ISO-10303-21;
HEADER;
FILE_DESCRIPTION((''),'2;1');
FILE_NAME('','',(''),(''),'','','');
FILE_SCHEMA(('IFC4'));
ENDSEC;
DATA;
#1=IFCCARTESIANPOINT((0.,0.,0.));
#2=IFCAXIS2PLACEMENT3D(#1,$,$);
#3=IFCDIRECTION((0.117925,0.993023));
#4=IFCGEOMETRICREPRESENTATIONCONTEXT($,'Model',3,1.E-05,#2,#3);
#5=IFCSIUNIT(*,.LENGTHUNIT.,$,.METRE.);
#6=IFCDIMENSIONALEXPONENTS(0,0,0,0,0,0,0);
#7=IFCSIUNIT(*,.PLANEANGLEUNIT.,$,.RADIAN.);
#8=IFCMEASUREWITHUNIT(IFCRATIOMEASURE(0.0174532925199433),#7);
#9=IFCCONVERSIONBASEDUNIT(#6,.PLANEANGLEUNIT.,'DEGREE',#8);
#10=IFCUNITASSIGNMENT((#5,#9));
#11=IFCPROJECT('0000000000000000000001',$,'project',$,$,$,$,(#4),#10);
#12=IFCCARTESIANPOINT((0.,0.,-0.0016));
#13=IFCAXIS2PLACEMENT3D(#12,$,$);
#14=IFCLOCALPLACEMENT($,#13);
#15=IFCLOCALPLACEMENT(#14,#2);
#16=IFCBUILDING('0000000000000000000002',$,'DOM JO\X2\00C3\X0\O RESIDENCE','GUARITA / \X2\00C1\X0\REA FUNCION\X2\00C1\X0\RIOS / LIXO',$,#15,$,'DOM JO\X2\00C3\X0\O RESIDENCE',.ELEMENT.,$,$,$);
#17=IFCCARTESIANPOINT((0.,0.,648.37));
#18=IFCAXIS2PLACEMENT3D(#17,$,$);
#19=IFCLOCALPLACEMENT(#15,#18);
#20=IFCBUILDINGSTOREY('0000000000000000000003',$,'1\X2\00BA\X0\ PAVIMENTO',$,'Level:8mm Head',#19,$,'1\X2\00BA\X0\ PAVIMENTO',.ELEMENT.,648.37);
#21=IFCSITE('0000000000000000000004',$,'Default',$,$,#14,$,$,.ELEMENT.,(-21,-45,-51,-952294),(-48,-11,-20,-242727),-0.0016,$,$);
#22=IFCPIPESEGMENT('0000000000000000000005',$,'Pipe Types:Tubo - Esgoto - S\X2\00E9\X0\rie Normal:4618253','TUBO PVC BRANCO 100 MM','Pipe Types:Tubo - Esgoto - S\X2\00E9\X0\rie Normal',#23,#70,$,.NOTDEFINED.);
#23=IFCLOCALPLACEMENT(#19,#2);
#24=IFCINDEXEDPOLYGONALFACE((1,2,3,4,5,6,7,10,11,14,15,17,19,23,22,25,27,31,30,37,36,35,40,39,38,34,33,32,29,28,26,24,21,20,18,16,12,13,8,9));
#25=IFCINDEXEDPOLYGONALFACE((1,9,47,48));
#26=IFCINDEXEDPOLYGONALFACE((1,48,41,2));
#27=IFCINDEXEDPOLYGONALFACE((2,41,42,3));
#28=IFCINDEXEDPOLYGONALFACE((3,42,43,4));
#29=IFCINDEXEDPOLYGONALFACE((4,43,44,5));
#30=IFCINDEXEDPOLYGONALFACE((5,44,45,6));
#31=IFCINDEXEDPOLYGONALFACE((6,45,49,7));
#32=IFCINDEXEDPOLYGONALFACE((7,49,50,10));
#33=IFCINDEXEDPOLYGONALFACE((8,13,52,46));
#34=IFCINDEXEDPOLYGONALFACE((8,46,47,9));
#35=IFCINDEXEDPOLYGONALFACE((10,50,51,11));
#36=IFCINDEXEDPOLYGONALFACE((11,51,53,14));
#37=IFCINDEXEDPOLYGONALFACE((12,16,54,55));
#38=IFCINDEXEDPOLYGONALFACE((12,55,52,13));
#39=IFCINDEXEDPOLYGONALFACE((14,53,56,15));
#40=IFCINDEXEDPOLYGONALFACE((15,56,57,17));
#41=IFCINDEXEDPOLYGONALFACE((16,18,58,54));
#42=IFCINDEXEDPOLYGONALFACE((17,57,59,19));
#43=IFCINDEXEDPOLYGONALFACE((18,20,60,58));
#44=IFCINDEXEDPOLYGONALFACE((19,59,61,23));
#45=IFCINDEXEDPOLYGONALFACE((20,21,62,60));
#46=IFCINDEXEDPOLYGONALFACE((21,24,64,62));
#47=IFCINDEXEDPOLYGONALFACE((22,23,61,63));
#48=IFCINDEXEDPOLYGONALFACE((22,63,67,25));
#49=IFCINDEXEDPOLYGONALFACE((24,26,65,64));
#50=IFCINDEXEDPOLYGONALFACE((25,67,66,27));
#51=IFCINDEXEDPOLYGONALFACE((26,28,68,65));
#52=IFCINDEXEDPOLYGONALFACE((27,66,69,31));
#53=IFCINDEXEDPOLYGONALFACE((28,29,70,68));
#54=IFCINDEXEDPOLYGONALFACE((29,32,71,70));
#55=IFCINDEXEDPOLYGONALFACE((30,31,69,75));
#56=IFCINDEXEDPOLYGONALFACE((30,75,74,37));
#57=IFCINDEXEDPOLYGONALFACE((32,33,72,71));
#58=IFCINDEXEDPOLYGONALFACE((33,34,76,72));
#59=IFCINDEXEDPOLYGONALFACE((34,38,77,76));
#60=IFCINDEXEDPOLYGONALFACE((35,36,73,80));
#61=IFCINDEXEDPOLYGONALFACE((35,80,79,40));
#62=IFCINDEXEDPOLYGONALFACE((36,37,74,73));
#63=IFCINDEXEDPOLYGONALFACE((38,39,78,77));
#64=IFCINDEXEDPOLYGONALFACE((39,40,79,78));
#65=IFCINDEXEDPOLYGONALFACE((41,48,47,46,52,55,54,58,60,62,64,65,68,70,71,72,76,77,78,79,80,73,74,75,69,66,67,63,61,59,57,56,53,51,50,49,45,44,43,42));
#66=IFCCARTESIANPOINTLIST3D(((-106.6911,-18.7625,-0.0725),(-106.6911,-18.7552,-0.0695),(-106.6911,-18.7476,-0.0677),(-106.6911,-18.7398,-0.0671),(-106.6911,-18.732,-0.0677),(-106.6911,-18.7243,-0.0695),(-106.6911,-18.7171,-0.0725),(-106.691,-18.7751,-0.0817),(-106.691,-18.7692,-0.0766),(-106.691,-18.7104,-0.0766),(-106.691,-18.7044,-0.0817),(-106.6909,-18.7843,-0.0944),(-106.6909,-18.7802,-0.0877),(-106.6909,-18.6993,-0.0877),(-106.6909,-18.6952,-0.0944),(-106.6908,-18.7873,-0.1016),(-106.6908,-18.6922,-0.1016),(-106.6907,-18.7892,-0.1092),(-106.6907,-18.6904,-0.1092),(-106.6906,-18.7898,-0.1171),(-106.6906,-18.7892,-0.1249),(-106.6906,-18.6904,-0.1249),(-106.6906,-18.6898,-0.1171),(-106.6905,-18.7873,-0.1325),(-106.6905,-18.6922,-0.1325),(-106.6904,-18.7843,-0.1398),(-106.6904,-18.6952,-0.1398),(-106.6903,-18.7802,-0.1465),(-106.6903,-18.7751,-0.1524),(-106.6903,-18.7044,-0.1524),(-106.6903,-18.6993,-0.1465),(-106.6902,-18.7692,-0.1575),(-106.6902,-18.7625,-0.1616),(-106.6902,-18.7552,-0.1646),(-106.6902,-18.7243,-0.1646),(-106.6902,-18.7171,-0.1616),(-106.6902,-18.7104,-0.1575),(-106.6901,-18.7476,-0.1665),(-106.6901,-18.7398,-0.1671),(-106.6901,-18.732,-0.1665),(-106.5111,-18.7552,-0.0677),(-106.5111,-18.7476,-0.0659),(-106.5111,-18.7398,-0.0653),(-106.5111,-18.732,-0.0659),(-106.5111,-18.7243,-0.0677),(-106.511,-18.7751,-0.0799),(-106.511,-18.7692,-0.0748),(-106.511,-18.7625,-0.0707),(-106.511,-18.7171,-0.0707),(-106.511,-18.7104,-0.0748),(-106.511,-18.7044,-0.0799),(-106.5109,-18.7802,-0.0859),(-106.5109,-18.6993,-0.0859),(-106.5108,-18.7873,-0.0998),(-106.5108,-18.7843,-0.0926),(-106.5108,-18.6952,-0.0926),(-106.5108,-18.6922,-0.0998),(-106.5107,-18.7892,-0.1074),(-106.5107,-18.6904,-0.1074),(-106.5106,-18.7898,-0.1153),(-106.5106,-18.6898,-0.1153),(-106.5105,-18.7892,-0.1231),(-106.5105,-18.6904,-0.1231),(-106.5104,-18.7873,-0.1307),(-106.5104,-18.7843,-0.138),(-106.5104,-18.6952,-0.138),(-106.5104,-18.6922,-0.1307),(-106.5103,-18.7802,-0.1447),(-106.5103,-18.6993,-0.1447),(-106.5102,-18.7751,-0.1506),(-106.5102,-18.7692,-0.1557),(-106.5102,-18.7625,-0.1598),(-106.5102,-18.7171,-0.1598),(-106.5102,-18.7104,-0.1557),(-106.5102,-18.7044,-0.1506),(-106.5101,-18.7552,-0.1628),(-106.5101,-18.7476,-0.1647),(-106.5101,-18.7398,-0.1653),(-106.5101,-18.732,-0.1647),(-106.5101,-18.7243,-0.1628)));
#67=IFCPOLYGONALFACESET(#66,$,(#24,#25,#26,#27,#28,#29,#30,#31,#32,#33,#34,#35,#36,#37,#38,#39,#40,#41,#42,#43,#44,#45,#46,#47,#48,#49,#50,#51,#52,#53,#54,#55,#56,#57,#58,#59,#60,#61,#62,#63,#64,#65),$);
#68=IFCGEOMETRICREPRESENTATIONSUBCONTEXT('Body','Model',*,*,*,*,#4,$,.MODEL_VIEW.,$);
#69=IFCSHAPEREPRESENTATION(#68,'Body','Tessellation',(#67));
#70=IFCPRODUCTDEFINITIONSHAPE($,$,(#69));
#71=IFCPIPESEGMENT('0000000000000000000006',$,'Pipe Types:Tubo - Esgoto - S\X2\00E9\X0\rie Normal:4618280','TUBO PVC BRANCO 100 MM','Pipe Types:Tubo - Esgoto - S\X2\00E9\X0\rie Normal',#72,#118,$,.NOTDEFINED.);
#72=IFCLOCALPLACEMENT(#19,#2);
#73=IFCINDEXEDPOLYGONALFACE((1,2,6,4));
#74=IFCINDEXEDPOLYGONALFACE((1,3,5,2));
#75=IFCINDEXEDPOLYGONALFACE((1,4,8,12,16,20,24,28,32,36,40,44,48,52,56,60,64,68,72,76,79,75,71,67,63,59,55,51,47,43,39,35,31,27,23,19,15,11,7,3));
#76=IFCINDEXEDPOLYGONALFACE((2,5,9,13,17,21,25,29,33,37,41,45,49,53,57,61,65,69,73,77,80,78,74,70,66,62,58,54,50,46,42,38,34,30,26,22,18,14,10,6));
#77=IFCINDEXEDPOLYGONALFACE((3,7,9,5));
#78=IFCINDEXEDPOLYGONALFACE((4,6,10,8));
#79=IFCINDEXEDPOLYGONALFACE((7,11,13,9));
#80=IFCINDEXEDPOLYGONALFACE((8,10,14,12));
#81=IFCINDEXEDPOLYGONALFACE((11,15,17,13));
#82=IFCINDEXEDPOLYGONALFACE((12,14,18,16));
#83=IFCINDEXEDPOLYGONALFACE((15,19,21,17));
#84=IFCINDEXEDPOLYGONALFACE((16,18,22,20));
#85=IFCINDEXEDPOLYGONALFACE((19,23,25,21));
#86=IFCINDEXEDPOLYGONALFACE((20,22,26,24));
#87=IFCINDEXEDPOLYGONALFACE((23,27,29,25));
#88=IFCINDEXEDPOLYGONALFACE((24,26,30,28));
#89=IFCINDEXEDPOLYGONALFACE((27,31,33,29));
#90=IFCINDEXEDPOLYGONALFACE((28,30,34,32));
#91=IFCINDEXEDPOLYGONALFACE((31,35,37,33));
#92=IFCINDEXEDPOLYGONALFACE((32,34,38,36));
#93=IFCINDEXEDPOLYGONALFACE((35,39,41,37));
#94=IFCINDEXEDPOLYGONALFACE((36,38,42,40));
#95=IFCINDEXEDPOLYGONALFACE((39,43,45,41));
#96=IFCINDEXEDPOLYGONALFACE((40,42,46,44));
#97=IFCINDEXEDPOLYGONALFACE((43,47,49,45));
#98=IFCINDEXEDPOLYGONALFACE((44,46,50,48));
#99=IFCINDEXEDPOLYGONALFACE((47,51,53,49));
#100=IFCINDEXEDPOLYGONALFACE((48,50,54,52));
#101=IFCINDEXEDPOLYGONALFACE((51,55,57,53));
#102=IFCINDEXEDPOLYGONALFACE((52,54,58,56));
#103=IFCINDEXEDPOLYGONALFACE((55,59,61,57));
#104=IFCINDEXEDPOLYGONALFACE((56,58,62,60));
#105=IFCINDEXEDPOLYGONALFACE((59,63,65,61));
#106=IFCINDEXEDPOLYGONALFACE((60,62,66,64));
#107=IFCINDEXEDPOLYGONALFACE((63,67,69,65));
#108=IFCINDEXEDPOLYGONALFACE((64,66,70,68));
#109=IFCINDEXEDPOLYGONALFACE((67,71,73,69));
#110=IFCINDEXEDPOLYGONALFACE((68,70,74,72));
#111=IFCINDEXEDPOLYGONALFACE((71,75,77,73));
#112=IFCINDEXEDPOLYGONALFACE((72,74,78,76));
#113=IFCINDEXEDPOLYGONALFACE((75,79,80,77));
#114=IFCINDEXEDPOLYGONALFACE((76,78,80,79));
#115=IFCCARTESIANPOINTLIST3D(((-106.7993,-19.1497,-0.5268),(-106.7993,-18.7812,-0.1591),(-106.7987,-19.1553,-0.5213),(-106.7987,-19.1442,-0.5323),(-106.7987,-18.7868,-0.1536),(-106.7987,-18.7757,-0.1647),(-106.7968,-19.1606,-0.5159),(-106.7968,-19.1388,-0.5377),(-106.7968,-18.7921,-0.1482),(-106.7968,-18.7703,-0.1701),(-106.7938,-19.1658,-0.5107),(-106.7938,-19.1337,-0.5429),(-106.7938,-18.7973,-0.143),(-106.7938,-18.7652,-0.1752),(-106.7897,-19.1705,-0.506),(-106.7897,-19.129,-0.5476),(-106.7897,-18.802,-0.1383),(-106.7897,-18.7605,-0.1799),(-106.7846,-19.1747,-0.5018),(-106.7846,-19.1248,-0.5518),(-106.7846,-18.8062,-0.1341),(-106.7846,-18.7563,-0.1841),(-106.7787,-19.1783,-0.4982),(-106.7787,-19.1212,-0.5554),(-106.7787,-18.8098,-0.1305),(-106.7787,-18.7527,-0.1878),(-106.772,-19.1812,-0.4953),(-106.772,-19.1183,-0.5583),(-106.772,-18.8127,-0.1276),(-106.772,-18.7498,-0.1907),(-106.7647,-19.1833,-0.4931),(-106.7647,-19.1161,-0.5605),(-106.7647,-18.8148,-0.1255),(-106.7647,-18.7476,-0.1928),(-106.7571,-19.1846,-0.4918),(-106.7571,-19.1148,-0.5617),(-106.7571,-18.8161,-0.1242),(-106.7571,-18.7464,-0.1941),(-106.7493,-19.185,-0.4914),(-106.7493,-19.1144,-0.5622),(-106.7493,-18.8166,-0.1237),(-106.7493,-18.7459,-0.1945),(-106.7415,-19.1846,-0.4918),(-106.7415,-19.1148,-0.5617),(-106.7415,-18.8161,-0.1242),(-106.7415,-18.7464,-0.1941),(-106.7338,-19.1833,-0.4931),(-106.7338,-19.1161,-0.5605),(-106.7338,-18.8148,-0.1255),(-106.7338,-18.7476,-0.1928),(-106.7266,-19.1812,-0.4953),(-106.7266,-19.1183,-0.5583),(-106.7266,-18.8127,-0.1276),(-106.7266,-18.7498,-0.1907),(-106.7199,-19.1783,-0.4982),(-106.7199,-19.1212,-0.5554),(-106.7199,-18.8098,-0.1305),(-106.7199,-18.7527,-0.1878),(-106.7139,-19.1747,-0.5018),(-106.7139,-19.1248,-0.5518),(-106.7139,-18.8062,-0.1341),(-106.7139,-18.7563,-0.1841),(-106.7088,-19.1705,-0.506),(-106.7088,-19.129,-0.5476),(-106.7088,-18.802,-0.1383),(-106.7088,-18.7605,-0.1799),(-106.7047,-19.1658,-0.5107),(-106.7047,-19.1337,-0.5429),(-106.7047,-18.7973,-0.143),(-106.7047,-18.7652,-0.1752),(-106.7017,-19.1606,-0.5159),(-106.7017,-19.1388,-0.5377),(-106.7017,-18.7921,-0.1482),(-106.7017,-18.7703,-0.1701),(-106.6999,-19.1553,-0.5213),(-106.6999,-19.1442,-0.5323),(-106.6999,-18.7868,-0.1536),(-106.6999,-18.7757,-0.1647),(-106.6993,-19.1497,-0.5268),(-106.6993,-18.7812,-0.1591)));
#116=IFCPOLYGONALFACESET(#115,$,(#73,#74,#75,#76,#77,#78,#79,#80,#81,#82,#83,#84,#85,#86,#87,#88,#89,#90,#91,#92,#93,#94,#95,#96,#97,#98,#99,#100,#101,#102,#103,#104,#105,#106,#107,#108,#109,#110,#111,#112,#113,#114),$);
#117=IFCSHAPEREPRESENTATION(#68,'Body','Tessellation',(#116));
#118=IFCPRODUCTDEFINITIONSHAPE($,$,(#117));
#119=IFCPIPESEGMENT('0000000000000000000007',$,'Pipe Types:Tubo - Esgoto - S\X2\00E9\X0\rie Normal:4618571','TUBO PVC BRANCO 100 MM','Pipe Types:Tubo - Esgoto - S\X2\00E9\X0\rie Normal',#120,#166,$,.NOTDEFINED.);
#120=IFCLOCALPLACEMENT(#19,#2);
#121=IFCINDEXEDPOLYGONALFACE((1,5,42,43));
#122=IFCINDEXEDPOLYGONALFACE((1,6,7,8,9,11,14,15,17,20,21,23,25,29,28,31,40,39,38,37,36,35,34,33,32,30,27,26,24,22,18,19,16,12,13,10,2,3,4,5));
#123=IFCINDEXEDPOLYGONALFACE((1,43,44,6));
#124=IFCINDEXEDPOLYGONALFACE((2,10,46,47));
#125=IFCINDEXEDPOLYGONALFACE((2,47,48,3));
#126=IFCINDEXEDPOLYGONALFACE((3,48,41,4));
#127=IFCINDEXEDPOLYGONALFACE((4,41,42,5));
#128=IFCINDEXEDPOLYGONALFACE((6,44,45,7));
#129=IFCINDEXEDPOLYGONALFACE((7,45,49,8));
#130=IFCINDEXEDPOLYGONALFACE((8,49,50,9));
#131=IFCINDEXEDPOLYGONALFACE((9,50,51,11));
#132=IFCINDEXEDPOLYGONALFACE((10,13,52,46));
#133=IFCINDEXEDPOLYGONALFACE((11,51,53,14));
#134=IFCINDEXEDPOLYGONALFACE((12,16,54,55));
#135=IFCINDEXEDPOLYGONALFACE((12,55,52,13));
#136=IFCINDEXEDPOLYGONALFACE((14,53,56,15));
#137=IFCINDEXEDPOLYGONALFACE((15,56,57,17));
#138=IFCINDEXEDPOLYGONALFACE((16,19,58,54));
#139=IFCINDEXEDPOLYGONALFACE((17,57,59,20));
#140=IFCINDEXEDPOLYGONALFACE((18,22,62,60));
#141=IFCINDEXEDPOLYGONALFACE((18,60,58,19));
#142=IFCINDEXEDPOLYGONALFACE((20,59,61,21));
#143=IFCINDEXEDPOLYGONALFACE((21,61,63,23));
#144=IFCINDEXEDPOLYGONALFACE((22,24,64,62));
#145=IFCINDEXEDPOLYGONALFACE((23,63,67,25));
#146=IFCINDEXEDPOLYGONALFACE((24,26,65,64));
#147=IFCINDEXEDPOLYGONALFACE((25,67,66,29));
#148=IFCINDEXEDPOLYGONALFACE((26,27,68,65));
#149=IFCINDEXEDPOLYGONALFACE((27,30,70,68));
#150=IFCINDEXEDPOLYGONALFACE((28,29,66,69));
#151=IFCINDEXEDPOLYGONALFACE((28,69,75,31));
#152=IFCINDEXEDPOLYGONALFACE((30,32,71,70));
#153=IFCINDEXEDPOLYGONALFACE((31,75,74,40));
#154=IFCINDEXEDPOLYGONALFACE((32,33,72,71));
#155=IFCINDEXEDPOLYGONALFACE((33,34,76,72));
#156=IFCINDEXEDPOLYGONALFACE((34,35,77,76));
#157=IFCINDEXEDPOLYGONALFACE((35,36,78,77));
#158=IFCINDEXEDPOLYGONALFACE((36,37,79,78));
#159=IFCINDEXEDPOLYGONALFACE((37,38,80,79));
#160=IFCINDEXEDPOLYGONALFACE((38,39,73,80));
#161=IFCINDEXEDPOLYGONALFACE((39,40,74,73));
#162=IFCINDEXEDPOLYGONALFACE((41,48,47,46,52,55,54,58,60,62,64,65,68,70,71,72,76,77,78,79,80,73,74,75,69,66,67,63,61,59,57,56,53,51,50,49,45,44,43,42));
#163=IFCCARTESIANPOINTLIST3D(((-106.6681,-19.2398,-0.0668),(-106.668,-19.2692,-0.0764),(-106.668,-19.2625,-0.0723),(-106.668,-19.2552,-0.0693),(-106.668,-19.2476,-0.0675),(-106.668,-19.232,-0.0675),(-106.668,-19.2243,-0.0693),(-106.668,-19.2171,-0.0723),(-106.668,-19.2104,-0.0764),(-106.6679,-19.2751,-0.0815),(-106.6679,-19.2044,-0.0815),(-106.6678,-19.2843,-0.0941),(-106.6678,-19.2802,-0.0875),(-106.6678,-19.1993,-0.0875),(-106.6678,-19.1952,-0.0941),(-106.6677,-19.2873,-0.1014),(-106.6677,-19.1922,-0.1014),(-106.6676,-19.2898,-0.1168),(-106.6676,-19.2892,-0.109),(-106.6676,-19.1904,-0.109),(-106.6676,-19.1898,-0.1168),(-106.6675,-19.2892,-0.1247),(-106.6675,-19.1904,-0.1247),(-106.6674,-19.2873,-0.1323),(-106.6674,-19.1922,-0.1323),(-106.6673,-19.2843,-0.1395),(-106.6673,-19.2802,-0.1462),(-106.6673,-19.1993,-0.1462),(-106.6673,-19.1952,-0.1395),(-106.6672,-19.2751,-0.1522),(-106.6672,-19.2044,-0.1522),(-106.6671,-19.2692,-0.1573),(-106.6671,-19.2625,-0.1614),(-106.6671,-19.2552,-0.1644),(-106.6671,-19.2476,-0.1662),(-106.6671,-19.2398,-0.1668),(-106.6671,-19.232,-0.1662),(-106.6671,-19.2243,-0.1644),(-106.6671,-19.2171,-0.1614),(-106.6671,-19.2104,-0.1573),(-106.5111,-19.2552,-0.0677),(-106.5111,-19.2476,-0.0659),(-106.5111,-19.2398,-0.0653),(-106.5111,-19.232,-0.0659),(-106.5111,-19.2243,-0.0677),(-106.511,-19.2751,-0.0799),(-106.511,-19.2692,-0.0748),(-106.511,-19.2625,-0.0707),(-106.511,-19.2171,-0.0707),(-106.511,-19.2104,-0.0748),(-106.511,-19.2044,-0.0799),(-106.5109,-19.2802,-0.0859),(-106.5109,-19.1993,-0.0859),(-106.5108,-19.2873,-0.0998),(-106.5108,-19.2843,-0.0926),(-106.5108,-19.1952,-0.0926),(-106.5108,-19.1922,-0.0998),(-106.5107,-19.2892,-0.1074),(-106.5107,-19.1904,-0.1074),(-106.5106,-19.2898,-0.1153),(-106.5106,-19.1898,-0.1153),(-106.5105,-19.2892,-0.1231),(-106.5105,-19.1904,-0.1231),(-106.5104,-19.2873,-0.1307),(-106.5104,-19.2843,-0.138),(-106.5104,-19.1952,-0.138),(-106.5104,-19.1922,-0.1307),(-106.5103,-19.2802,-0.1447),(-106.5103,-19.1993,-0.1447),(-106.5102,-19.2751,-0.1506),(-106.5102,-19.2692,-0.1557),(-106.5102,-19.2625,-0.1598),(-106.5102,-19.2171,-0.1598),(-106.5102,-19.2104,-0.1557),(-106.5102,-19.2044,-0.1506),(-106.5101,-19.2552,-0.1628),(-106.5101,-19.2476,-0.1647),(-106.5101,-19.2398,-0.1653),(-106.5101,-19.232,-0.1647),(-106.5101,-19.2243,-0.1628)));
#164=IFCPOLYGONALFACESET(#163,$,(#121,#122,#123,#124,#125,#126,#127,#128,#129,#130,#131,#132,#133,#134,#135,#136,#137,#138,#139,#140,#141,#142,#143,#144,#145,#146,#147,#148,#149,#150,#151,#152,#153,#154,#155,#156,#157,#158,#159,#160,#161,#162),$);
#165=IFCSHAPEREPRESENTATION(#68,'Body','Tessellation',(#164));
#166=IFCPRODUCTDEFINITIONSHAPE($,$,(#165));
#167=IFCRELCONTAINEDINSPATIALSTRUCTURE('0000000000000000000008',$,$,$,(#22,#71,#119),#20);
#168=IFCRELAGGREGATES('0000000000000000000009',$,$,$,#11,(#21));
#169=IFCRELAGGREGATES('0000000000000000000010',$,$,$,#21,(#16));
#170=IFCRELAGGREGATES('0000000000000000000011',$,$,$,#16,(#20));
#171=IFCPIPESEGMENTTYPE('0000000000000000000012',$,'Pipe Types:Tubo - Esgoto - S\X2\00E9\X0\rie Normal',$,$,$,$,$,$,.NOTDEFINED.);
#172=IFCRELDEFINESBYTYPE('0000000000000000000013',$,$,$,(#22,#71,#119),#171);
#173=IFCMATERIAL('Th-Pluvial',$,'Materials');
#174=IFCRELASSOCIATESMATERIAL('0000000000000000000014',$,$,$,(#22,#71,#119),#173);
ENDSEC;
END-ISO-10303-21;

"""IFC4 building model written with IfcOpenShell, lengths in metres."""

from ifc_helpers import new_model, entity, si_unit, converted_unit, direction, frame, origin, place, context, subcontext, project, spatial, indexed_curve, outline, extrude, material, type_object, element, save


model = new_model("IFC4")

# Units and contexts
model_context = context("Model", 3, precision=1e-05, world=origin(), true_north=direction((0.117925, 0.993023)))
body_context = subcontext(model_context, "Body", "Model", "MODEL_VIEW")
ifc_project = project(units=[si_unit("LENGTHUNIT", "METRE"), converted_unit("PLANEANGLEUNIT", "DEGREE", entity("IfcRatioMeasure", 0.0174532925199433), si_unit("PLANEANGLEUNIT", "RADIAN"), dimensions=[0, 0, 0, 0, 0, 0, 0])], contexts=[model_context])

# Site, building, storey
site_placement = place(None, frame((0.0, 0.0, -0.0016)))
site = spatial("IfcSite", under=ifc_project, at=site_placement, Name="Default", CompositionType="ELEMENT", RefLatitude=(-21, -45, -51, -952294), RefLongitude=(-48, -11, -20, -242727), RefElevation=-0.0016)
building_placement = place(site_placement, origin())
building = spatial("IfcBuilding", under=site, at=building_placement, Name="DOM JOÃO RESIDENCE", Description="GUARITA / ÁREA FUNCIONÁRIOS / LIXO", LongName="DOM JOÃO RESIDENCE", CompositionType="ELEMENT")
storey_placement = place(building_placement, frame((0.0, 0.0, 648.37)))
storey = spatial("IfcBuildingStorey", under=building, at=storey_placement, Name="1º PAVIMENTO", ObjectType="Level:8mm Head", LongName="1º PAVIMENTO", CompositionType="ELEMENT", Elevation=648.37)

# Pipe segments
ifc_material = material(Name="Th-Pluvial", Category="Materials")
pipe_segment_type = type_object("IfcPipeSegmentType", Name="Pipe Types:Tubo - Esgoto - Série Normal", PredefinedType="NOTDEFINED")
pipe_segment_1_placement = place(storey_placement, frame((-106.6927, -18.7914, -0.1687)))
element("IfcPipeSegment", 1, at=pipe_segment_1_placement, inside=storey, type_object=pipe_segment_type, material=ifc_material, Name="Pipe Types:Tubo - Esgoto - Série Normal:4618253", Description="TUBO PVC BRANCO 100 MM", ObjectType="Pipe Types:Tubo - Esgoto - Série Normal", PredefinedType="NOTDEFINED", context=body_context, shape_type="SweptSolid", body=[
    extrude(outline(indexed_curve([(0.05, 0.0), (0.0494, 0.0078), (0.0476, 0.0155), (0.0446, 0.0227), (0.0405, 0.0294), (0.0354, 0.0354), (0.0294, 0.0405), (0.0227, 0.0446), (0.0155, 0.0476), (0.0078, 0.0494), (0.0, 0.05), (-0.0078, 0.0494), (-0.0155, 0.0476), (-0.0227, 0.0446), (-0.0294, 0.0405), (-0.0354, 0.0354), (-0.0405, 0.0294), (-0.0446, 0.0227), (-0.0476, 0.0155), (-0.0494, 0.0078), (-0.05, 0.0), (-0.0494, -0.0078), (-0.0476, -0.0155), (-0.0446, -0.0227), (-0.0405, -0.0294), (-0.0354, -0.0354), (-0.0294, -0.0405), (-0.0227, -0.0446), (-0.0155, -0.0476), (-0.0078, -0.0494), (0.0, -0.05), (0.0078, -0.0494), (0.0155, -0.0476), (0.0227, -0.0446), (0.0294, -0.0405), (0.0354, -0.0354), (0.0405, -0.0294), (0.0446, -0.0227), (0.0476, -0.0155), (0.0494, -0.0078), (0.05, 0.0)], self_intersect=False)), frame((0.0021, 0.0516, 0.0516), z_axis=(0.99995, 0.0, 0.01), x_axis=(0.0, 1.0, 0.0)), (0.0, 0.0, 1.0), 0.18),
])
pipe_segment_2_placement = place(storey_placement, frame((-106.8009, -19.1866, -0.5638)))
element("IfcPipeSegment", 2, at=pipe_segment_2_placement, inside=storey, type_object=pipe_segment_type, material=ifc_material, Name="Pipe Types:Tubo - Esgoto - Série Normal:4618280", Description="TUBO PVC BRANCO 100 MM", ObjectType="Pipe Types:Tubo - Esgoto - Série Normal", PredefinedType="NOTDEFINED", context=body_context, shape_type="SweptSolid", body=[
    extrude(outline(indexed_curve([(0.05, 0.0), (0.0494, 0.0078), (0.0476, 0.0155), (0.0446, 0.0227), (0.0405, 0.0294), (0.0354, 0.0354), (0.0294, 0.0405), (0.0227, 0.0446), (0.0155, 0.0476), (0.0078, 0.0494), (0.0, 0.05), (-0.0078, 0.0494), (-0.0155, 0.0476), (-0.0227, 0.0446), (-0.0294, 0.0405), (-0.0354, 0.0354), (-0.0405, 0.0294), (-0.0446, 0.0227), (-0.0476, 0.0155), (-0.0494, 0.0078), (-0.05, 0.0), (-0.0494, -0.0078), (-0.0476, -0.0155), (-0.0446, -0.0227), (-0.0405, -0.0294), (-0.0354, -0.0354), (-0.0294, -0.0405), (-0.0227, -0.0446), (-0.0155, -0.0476), (-0.0078, -0.0494), (0.0, -0.05), (0.0078, -0.0494), (0.0155, -0.0476), (0.0227, -0.0446), (0.0294, -0.0405), (0.0354, -0.0354), (0.0405, -0.0294), (0.0446, -0.0227), (0.0476, -0.0155), (0.0494, -0.0078), (0.05, 0.0)], self_intersect=False)), frame((0.0516, 0.0369, 0.037), z_axis=(0.0, 0.707891, 0.706321), x_axis=(1.0, 0.0, 0.0)), (0.0, 0.0, 1.0), 0.5205),
])
pipe_segment_3_placement = place(storey_placement, frame((-106.6696, -19.2914, -0.1684)))
element("IfcPipeSegment", 3, at=pipe_segment_3_placement, inside=storey, type_object=pipe_segment_type, material=ifc_material, Name="Pipe Types:Tubo - Esgoto - Série Normal:4618571", Description="TUBO PVC BRANCO 100 MM", ObjectType="Pipe Types:Tubo - Esgoto - Série Normal", PredefinedType="NOTDEFINED", context=body_context, shape_type="SweptSolid", body=[
    extrude(outline(indexed_curve([(0.05, 0.0), (0.0494, 0.0078), (0.0476, 0.0155), (0.0446, 0.0227), (0.0405, 0.0294), (0.0354, 0.0354), (0.0294, 0.0405), (0.0227, 0.0446), (0.0155, 0.0476), (0.0078, 0.0494), (0.0, 0.05), (-0.0078, 0.0494), (-0.0155, 0.0476), (-0.0227, 0.0446), (-0.0294, 0.0405), (-0.0354, 0.0354), (-0.0405, 0.0294), (-0.0446, 0.0227), (-0.0476, 0.0155), (-0.0494, 0.0078), (-0.05, 0.0), (-0.0494, -0.0078), (-0.0476, -0.0155), (-0.0446, -0.0227), (-0.0405, -0.0294), (-0.0354, -0.0354), (-0.0294, -0.0405), (-0.0227, -0.0446), (-0.0155, -0.0476), (-0.0078, -0.0494), (0.0, -0.05), (0.0078, -0.0494), (0.0155, -0.0476), (0.0227, -0.0446), (0.0294, -0.0405), (0.0354, -0.0354), (0.0405, -0.0294), (0.0446, -0.0227), (0.0476, -0.0155), (0.0494, -0.0078), (0.05, 0.0)], self_intersect=False)), frame((0.0021, 0.0516, 0.0516), z_axis=(0.99995, 0.0, 0.01), x_axis=(0.0, 1.0, 0.0)), (0.0, 0.0, 1.0), 0.157),
])

save(model, "model.ifc")
